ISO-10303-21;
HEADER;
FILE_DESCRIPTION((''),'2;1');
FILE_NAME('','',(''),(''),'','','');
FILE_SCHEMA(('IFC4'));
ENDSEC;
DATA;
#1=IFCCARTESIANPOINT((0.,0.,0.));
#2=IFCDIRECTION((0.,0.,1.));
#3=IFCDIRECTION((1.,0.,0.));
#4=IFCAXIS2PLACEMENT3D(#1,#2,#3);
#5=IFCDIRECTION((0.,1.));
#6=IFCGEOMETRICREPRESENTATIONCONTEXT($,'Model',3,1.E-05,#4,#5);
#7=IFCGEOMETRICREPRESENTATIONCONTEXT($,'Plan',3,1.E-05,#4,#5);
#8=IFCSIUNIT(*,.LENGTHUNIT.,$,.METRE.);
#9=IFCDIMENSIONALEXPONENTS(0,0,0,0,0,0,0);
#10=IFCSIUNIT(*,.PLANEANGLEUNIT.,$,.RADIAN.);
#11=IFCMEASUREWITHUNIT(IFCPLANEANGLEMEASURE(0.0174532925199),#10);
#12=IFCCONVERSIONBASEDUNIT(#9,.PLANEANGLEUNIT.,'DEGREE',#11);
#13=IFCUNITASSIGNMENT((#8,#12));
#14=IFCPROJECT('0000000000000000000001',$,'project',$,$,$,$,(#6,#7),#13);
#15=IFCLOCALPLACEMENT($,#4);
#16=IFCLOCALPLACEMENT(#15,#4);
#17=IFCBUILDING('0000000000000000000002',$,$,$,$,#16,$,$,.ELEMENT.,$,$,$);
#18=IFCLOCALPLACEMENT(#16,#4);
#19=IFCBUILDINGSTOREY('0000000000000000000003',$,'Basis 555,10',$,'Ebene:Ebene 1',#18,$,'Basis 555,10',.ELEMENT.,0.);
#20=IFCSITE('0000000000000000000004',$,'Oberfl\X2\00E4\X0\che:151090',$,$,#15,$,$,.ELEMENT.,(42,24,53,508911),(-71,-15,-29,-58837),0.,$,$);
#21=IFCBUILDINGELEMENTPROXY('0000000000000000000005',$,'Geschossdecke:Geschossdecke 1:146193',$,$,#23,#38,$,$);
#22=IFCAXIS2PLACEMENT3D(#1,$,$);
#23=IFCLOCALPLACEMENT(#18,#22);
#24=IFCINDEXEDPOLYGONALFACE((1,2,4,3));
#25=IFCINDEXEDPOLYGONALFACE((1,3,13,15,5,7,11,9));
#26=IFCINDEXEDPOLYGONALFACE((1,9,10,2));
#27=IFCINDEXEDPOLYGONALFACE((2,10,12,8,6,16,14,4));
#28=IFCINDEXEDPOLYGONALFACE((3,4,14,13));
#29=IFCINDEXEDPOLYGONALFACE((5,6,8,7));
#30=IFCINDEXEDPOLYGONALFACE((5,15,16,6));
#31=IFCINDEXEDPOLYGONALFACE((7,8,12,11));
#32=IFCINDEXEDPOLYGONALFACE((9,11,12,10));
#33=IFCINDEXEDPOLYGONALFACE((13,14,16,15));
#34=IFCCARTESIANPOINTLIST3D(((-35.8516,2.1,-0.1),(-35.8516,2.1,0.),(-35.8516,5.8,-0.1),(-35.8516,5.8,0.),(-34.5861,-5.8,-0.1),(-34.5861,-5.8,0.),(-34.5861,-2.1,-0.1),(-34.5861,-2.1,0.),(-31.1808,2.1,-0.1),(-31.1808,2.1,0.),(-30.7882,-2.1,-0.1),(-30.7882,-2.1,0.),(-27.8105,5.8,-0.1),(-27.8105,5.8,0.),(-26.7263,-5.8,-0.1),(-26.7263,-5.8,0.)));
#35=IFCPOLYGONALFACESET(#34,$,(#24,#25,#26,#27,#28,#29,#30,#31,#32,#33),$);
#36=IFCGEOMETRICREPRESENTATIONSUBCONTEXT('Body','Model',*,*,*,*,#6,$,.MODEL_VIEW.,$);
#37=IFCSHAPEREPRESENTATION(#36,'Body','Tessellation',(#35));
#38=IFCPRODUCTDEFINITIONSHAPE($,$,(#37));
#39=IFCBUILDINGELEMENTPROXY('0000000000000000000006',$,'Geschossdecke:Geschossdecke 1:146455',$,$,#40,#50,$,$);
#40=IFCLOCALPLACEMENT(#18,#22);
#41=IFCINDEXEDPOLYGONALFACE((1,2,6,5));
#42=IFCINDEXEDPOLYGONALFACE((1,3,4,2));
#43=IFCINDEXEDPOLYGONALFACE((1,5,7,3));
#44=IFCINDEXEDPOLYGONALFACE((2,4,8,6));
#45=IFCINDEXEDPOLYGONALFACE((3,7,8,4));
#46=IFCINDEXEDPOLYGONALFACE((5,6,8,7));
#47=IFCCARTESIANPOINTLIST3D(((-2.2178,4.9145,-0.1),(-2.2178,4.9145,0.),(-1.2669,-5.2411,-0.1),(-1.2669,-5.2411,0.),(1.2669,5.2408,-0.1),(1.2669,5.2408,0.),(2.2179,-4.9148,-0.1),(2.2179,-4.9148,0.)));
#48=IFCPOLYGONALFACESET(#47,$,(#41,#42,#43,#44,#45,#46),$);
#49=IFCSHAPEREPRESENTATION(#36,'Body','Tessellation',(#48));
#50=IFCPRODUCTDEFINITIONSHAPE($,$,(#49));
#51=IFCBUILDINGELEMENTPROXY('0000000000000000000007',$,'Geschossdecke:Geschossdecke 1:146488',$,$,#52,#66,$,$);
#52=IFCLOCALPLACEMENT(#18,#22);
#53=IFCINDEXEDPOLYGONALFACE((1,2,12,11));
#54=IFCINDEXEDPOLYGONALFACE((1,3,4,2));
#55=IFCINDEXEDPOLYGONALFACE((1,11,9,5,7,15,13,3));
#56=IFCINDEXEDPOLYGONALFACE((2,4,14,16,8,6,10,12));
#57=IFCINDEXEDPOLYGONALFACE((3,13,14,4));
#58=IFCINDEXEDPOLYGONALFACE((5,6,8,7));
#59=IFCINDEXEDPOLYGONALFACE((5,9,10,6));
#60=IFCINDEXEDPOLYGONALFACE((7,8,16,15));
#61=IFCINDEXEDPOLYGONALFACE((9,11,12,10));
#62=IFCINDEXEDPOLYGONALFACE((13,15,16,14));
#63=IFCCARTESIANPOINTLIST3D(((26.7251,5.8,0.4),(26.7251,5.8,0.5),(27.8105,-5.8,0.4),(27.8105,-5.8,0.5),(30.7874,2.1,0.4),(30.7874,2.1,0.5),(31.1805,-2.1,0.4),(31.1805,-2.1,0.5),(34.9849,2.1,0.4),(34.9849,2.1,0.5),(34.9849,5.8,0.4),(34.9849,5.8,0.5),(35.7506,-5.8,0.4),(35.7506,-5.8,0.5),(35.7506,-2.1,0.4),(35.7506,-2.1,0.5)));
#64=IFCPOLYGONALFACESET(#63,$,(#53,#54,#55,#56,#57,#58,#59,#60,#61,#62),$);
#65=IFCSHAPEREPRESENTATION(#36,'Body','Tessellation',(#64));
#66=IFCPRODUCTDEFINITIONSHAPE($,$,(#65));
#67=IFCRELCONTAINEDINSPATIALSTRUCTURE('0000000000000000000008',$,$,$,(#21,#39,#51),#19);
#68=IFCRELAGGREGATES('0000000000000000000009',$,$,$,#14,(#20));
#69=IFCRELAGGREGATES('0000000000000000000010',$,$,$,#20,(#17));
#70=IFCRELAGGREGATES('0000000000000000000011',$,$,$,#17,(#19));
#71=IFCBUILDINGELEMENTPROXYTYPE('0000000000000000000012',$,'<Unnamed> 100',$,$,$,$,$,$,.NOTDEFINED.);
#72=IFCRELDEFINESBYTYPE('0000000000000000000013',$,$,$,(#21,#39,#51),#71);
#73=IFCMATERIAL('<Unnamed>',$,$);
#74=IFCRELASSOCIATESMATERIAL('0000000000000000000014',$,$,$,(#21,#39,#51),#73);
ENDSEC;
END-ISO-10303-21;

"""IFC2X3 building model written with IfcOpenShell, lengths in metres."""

from ifc_helpers import new_model, entity, si_unit, converted_unit, direction, frame, origin_with_axes, place, context, subcontext, project, spatial, polyline, outline, extrude, material, type_object, element, save


model = new_model("IFC2X3")

# Units and contexts
model_context = context("Model", 3, precision=1e-05, world=origin_with_axes(), true_north=direction((0.0, 1.0)))
plan_context = context("Plan", 3, precision=1e-05, world=origin_with_axes(), true_north=direction((0.0, 1.0)))
body_context = subcontext(model_context, "Body", "Model", "MODEL_VIEW")
ifc_project = project(units=[si_unit("LENGTHUNIT", "METRE"), converted_unit("PLANEANGLEUNIT", "DEGREE", entity("IfcPlaneAngleMeasure", 0.0174532925199), si_unit("PLANEANGLEUNIT", "RADIAN"), dimensions=[0, 0, 0, 0, 0, 0, 0])], contexts=[model_context, plan_context])

# Site, building, storey
site_placement = place(None, origin_with_axes())
site = spatial("IfcSite", under=ifc_project, at=site_placement, Name="Oberfläche:151090", CompositionType="ELEMENT", RefLatitude=(42, 24, 53, 508911), RefLongitude=(-71, -15, -29, -58837), RefElevation=0.0)
building_placement = place(site_placement, origin_with_axes())
building = spatial("IfcBuilding", under=site, at=building_placement, CompositionType="ELEMENT")
storey_placement = place(building_placement, origin_with_axes())
storey = spatial("IfcBuildingStorey", under=building, at=storey_placement, Name="Basis 555,10", ObjectType="Ebene:Ebene 1", LongName="Basis 555,10", CompositionType="ELEMENT", Elevation=0.0)

# Building element proxies
ifc_material = material(Name="<Unnamed>")
building_element_proxy_type = type_object("IfcBuildingElementProxyType", Name="<Unnamed> 100", PredefinedType="NOTDEFINED")
proxy_1_placement = place(storey_placement, frame((-35.8516, 2.1, 0.0), z_axis=(0.0, 0.0, 1.0), x_axis=(1.0, 0.0, 0.0)))
element("IfcBuildingElementProxy", 1, at=proxy_1_placement, inside=storey, type_object=building_element_proxy_type, material=ifc_material, Name="Geschossdecke:Geschossdecke 1:146193", context=body_context, shape_type="SweptSolid", body=[
    extrude(outline(polyline([(0.0, 0.0), (4.6708, 0.0), (5.0633, -4.2), (1.2655, -4.2), (1.2655, -7.9), (9.1252, -7.9), (8.0411, 3.7), (0.0, 3.7), (0.0, 0.0)])), frame((0.0, 0.0, -0.1), z_axis=(0.0, 0.0, 1.0), x_axis=(1.0, 0.0, 0.0)), (0.0, 0.0, 1.0), 0.1),
])
proxy_2_placement = place(storey_placement, frame((2.2179, -4.9148, 0.0), z_axis=(0.0, 0.0, 1.0), x_axis=(1.0, 0.0, 0.0)))
element("IfcBuildingElementProxy", 2, at=proxy_2_placement, inside=storey, type_object=building_element_proxy_type, material=ifc_material, Name="Geschossdecke:Geschossdecke 1:146455", context=body_context, shape_type="SweptSolid", body=[
    extrude(outline(polyline([(0.0, 0.0), (-0.951, 10.1556), (-4.4357, 9.8293), (-3.4848, -0.3263), (0.0, 0.0)])), frame((0.0, 0.0, -0.1), z_axis=(0.0, 0.0, 1.0), x_axis=(1.0, 0.0, 0.0)), (0.0, 0.0, 1.0), 0.1),
])
proxy_3_placement = place(storey_placement, frame((35.7506, -5.8, 0.5), z_axis=(0.0, 0.0, 1.0), x_axis=(1.0, 0.0, 0.0)))
element("IfcBuildingElementProxy", 3, at=proxy_3_placement, inside=storey, type_object=building_element_proxy_type, material=ifc_material, Name="Geschossdecke:Geschossdecke 1:146488", context=body_context, shape_type="SweptSolid", body=[
    extrude(outline(polyline([(0.0, 0.0), (0.0, 3.7), (-4.5701, 3.7), (-4.9632, 7.9), (-0.7658, 7.9), (-0.7658, 11.6), (-9.0255, 11.6), (-7.9401, 0.0), (0.0, 0.0)])), frame((0.0, 0.0, -0.1), z_axis=(0.0, 0.0, 1.0), x_axis=(1.0, 0.0, 0.0)), (0.0, 0.0, 1.0), 0.1),
])

save(model, "model.ifc")
